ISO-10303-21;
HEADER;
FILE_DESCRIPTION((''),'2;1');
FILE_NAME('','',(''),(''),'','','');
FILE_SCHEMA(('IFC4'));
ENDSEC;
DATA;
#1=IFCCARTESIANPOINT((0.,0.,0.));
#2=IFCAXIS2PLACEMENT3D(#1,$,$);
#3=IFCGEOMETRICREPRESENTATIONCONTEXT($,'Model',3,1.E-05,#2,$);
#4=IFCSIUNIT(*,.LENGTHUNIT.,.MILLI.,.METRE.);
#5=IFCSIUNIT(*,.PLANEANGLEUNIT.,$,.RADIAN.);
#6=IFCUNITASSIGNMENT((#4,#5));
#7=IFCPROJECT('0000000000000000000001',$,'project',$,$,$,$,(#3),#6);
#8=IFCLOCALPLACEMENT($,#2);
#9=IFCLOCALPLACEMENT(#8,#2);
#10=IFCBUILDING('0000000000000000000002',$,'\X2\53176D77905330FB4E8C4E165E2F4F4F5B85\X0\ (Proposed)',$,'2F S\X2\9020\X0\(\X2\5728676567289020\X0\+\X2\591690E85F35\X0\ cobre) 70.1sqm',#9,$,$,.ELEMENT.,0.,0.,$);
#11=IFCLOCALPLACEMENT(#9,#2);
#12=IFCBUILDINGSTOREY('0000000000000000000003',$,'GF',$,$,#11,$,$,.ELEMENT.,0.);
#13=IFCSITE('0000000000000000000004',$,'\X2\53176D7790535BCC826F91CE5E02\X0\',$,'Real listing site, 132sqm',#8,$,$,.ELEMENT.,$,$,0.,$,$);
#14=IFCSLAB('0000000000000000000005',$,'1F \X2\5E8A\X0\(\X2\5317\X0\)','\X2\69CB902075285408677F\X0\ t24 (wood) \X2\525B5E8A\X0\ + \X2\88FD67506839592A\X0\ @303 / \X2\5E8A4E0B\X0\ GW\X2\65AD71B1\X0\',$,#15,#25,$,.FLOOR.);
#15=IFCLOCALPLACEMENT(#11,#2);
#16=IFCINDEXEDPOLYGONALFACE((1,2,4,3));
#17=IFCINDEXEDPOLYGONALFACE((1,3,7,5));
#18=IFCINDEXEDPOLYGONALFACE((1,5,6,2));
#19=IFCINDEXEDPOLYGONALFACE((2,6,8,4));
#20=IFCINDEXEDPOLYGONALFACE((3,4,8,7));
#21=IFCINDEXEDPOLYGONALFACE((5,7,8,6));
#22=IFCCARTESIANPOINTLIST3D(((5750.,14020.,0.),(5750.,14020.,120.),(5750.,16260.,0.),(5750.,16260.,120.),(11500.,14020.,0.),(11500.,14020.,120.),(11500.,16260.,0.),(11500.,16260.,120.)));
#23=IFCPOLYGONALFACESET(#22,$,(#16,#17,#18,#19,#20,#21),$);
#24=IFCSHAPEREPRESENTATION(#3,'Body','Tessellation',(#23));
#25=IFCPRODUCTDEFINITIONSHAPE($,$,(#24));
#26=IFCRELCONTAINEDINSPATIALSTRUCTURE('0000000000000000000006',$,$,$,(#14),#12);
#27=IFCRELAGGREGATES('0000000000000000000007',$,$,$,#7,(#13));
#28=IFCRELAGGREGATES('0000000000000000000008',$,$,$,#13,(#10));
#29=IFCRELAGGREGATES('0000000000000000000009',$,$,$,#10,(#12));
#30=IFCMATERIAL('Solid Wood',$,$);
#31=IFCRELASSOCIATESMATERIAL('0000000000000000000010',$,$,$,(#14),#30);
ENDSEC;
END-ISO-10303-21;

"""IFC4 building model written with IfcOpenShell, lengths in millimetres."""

from ifc_helpers import new_model, si_unit, frame, frame_2d, origin, place, context, project, spatial, rectangle, extrude, material, element, save


model = new_model("IFC4")

# Units and contexts
model_context = context("Model", 3, precision=1e-05, world=origin())
ifc_project = project(units=[si_unit("LENGTHUNIT", "METRE", prefix="MILLI"), si_unit("PLANEANGLEUNIT", "RADIAN")], contexts=[model_context])

# Site, building, storey
site_placement = place(None, origin())
site = spatial("IfcSite", under=ifc_project, at=site_placement, Name="北海道富良野市", ObjectType="Real listing site, 132sqm", CompositionType="ELEMENT", RefElevation=0.0)
building_placement = place(site_placement, origin())
building = spatial("IfcBuilding", under=site, at=building_placement, Name="北海道・二世帯住宅 (Proposed)", ObjectType="2F S造(在来木造+外部張 cobre) 70.1sqm", CompositionType="ELEMENT", ElevationOfRefHeight=0.0, ElevationOfTerrain=0.0)
storey_placement = place(building_placement, origin())
storey = spatial("IfcBuildingStorey", under=building, at=storey_placement, Name="GF", CompositionType="ELEMENT", Elevation=0.0)

# Shared definitions
ifc_material_1 = material(Name="Solid Wood")

# Slab
slab_placement = place(storey_placement, frame((2875.0, 7010.0, 0.0)))
element("IfcSlab", 1, at=slab_placement, inside=storey, material=ifc_material_1, Name="1F 床(北)", Description="構造用合板 t24 (wood) 剛床 + 製材根太 @303 / 床下 GW断熱", PredefinedType="FLOOR", context=model_context, shape_type="SweptSolid", body=[
    extrude(rectangle(XDim=5750.0, YDim=2240.0, at=frame_2d((2875.0, 1120.0))), frame((2875.0, 7010.0, 0.0)), (0.0, 0.0, 1.0), 120.0),
])

save(model, "model.ifc")
